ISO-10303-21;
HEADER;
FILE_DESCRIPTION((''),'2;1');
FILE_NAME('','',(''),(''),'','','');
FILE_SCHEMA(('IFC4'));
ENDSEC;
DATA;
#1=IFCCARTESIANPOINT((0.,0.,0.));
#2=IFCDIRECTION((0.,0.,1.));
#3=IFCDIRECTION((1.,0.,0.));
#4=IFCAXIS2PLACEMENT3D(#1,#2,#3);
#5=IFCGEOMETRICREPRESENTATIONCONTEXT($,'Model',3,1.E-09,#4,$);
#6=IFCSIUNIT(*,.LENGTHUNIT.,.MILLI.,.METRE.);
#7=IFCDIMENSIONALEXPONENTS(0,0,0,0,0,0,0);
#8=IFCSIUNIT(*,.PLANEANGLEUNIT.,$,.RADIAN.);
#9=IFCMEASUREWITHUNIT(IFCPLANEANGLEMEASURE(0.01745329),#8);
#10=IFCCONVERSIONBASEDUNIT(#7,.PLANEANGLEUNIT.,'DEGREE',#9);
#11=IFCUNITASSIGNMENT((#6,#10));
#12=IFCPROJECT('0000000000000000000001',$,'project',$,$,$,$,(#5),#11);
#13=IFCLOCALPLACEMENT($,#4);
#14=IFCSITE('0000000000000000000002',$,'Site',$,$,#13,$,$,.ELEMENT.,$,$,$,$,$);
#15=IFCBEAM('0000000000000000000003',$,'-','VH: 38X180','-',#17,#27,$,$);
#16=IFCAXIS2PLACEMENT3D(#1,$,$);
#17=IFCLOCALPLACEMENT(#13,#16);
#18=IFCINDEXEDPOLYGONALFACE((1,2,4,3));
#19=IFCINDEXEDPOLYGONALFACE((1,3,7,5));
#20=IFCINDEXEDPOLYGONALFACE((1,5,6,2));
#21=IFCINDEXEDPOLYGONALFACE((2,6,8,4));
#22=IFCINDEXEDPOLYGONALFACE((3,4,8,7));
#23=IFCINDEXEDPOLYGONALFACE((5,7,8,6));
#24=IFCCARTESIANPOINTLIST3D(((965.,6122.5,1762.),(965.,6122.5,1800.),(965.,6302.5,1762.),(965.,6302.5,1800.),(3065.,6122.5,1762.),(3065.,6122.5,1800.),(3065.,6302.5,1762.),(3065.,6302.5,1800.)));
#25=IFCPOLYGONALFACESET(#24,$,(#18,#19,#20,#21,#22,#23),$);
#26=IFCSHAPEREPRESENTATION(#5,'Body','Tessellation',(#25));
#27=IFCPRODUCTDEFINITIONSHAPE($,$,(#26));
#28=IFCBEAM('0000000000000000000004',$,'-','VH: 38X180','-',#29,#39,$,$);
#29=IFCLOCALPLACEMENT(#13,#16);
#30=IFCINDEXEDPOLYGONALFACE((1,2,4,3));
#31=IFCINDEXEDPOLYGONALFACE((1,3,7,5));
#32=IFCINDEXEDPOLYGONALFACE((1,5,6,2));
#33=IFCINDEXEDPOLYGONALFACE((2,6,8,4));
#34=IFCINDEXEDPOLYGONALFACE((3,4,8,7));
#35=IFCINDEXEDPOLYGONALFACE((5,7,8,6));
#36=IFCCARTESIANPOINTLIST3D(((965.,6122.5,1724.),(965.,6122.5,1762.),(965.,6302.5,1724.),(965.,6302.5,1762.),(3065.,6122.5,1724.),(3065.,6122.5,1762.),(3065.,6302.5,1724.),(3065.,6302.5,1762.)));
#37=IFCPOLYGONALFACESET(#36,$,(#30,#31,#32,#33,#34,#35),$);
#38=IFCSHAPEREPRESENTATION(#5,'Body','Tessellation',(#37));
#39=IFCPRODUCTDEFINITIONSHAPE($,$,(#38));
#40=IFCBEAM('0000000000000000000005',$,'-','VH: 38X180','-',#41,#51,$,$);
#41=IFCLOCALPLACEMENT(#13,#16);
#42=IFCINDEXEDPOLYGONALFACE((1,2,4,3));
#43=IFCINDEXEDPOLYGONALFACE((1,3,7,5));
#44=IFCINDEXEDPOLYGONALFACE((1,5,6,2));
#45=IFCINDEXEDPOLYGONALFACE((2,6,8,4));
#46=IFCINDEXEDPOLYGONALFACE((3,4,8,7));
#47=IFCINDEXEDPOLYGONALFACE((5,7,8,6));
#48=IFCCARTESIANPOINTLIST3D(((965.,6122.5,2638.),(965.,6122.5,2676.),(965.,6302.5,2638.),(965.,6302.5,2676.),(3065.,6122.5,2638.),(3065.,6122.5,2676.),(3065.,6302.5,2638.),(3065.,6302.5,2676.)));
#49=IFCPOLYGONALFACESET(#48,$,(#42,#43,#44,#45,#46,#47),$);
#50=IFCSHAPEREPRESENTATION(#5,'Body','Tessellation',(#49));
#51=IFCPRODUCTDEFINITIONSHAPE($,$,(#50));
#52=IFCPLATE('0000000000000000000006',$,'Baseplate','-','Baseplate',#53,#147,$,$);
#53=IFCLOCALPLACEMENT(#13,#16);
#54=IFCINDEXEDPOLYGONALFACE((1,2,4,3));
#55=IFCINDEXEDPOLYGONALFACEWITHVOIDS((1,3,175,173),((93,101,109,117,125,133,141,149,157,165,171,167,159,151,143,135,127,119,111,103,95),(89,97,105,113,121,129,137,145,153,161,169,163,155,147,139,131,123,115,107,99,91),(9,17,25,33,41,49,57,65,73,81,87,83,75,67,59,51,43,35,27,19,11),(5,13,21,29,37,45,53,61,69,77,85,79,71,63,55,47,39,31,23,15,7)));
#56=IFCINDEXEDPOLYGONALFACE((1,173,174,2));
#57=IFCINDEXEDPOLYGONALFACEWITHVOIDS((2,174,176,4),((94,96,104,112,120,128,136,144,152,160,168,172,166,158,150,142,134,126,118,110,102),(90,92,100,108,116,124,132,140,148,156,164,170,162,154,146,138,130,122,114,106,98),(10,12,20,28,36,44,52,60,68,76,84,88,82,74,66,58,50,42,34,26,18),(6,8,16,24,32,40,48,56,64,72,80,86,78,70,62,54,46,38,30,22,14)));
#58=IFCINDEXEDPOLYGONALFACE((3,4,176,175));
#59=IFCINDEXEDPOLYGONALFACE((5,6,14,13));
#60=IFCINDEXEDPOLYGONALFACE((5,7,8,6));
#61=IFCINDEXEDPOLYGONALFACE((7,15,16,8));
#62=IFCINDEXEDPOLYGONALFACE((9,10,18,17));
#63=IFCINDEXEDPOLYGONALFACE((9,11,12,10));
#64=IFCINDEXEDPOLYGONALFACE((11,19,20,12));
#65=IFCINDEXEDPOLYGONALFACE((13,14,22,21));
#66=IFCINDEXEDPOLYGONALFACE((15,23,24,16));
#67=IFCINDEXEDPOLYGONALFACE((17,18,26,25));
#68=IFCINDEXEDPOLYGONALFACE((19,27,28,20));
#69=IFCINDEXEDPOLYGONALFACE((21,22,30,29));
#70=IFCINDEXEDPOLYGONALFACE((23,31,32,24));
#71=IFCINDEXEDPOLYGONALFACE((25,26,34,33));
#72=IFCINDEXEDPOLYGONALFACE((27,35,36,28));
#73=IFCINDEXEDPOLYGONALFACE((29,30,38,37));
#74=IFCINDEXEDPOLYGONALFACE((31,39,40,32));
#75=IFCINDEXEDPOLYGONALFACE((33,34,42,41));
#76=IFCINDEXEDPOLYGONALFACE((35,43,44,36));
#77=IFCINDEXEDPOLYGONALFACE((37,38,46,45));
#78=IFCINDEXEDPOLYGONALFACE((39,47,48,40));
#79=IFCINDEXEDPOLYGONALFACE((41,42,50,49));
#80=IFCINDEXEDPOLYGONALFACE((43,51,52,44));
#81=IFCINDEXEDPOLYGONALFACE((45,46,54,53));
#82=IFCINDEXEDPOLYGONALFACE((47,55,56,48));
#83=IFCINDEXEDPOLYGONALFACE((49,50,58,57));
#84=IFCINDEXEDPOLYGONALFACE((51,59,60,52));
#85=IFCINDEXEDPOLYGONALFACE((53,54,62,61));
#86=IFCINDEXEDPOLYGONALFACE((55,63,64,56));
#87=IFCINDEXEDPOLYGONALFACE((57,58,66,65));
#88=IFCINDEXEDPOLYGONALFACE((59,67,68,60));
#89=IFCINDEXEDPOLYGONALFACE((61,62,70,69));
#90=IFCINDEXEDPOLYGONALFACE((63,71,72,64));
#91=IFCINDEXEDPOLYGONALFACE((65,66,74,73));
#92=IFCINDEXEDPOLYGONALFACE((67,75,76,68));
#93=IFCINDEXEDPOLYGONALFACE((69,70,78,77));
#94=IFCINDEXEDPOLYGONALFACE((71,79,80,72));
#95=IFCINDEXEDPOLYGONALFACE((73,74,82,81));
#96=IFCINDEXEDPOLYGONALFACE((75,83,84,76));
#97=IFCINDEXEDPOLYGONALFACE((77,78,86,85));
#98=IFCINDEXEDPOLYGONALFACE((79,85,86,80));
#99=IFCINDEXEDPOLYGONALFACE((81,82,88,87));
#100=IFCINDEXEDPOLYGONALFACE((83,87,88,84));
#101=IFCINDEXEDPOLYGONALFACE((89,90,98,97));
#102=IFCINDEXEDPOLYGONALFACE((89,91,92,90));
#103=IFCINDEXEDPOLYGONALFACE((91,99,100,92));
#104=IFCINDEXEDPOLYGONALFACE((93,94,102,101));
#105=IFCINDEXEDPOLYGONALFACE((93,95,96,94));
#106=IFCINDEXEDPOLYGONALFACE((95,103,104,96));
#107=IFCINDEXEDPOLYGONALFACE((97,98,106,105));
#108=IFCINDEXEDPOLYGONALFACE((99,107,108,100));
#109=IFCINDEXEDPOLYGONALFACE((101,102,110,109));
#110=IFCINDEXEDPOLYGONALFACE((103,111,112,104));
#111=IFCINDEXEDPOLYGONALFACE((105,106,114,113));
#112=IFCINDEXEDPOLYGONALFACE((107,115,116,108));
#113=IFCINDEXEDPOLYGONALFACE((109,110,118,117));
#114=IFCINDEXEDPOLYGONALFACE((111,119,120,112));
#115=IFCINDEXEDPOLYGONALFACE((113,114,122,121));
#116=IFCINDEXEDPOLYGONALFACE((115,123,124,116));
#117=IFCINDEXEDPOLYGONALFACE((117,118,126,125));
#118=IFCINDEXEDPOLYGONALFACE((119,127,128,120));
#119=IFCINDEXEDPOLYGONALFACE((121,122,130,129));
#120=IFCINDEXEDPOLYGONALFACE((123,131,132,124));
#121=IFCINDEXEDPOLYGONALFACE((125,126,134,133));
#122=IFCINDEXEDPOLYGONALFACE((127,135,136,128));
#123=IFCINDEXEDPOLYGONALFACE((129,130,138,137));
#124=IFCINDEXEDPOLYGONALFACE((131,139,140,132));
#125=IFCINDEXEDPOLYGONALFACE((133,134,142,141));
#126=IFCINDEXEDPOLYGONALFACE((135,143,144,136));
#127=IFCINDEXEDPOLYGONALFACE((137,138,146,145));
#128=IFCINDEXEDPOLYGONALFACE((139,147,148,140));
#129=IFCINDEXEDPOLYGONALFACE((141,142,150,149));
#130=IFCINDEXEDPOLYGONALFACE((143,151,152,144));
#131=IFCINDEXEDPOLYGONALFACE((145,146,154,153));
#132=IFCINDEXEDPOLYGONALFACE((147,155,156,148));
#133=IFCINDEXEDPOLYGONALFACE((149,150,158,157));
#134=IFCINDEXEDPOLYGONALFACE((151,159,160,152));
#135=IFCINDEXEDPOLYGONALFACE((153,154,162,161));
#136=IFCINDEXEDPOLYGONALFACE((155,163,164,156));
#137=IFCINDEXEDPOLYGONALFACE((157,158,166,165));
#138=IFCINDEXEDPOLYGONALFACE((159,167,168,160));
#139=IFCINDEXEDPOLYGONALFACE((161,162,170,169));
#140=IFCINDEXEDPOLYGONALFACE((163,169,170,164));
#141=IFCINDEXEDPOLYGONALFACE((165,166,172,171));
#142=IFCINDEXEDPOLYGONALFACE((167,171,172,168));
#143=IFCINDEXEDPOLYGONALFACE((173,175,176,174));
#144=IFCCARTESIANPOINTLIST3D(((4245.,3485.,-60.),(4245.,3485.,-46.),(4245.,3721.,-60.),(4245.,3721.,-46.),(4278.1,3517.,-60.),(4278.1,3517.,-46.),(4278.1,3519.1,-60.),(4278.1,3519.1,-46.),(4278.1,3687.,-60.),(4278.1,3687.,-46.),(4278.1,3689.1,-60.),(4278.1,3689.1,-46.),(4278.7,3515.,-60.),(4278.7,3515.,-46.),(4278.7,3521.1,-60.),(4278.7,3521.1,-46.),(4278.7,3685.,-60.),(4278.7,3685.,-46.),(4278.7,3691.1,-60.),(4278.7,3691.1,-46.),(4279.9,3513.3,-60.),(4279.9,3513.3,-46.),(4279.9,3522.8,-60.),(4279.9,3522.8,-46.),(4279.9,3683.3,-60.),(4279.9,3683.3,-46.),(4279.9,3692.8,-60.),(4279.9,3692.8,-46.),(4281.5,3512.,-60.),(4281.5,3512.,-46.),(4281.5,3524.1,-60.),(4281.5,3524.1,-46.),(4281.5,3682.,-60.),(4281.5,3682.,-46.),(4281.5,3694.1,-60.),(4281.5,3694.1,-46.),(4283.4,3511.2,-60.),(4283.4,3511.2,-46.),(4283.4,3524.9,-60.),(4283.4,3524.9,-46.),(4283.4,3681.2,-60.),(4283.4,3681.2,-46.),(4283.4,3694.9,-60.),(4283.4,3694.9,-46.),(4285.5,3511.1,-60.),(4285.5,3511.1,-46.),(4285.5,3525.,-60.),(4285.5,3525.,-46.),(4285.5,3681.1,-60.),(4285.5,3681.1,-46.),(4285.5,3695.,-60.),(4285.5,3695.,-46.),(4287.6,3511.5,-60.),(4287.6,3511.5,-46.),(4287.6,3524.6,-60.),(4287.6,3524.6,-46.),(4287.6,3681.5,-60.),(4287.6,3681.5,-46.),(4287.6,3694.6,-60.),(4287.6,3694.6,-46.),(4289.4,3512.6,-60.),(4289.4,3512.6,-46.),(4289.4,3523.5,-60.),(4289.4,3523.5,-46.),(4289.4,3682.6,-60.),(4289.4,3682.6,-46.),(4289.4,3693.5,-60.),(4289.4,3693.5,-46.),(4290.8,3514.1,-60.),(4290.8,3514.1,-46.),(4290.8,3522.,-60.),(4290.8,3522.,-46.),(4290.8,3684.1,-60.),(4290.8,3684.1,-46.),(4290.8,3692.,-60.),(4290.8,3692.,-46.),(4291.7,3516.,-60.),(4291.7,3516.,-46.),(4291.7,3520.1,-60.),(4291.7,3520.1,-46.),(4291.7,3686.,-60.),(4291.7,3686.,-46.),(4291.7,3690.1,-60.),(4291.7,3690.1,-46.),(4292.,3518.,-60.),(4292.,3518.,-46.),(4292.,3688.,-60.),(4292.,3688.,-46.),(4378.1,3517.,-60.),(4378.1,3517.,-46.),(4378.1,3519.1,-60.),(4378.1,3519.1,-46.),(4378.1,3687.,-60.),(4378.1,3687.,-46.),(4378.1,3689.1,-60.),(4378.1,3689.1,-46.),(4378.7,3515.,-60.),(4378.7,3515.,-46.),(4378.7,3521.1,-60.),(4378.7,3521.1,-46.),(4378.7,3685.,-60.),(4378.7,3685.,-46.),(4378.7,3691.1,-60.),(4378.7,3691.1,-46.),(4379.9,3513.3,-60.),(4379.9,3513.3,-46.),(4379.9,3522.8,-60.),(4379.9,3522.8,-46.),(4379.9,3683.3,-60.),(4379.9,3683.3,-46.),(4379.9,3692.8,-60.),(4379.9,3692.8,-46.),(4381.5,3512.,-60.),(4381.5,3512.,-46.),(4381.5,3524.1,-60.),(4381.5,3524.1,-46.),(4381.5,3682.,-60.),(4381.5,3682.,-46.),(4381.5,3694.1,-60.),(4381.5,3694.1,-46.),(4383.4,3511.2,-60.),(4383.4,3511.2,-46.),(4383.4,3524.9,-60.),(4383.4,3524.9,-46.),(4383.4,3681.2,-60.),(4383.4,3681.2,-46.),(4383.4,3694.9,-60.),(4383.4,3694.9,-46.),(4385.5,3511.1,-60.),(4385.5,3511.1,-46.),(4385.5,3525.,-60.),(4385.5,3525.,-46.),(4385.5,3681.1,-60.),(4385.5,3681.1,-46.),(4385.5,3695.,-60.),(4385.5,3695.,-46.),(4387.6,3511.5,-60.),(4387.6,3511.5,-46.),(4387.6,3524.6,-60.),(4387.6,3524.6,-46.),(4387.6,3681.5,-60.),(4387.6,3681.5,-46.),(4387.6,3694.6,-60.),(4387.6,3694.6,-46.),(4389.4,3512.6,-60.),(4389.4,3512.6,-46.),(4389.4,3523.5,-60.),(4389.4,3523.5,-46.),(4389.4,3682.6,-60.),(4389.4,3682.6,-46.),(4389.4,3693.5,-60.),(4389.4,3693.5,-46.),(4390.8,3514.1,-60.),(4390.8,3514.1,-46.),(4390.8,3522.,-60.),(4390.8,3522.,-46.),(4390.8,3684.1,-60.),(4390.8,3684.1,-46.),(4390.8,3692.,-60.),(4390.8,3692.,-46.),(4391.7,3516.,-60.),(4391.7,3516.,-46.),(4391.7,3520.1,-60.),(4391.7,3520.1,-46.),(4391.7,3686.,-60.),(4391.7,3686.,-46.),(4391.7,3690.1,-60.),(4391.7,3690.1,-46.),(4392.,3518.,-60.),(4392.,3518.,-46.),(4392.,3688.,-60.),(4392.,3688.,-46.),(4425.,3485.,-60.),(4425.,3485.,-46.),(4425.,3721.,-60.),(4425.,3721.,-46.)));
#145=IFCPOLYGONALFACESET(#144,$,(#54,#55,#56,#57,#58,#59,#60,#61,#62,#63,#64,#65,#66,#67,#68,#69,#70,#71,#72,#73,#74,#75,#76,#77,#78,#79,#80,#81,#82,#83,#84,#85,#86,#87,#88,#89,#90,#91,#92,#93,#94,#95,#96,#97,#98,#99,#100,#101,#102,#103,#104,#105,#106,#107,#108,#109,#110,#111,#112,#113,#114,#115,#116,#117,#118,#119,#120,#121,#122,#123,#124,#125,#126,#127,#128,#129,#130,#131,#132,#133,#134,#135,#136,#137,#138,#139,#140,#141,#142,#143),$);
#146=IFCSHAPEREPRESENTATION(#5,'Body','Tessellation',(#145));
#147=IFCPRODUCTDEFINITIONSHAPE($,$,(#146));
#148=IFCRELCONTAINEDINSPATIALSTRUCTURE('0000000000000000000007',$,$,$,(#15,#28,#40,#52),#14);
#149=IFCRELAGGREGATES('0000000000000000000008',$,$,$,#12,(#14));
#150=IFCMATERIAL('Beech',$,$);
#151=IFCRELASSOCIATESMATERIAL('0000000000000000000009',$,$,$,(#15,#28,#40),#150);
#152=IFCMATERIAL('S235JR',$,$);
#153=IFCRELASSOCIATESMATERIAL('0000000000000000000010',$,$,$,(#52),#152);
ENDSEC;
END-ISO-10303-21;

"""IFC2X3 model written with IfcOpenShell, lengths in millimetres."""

from ifc_helpers import new_model, entity, si_unit, converted_unit, frame, frame_2d, origin, origin_with_axes, origin_2d, place, context, project, spatial, polyline, rectangle, circle, outline, extrude, material, element, save


model = new_model("IFC2X3")

# Units and contexts
model_context = context("Model", 3, precision=1e-09, world=origin_with_axes())
ifc_project = project(units=[si_unit("LENGTHUNIT", "METRE", prefix="MILLI"), converted_unit("PLANEANGLEUNIT", "DEGREE", entity("IfcPlaneAngleMeasure", 0.01745329), si_unit("PLANEANGLEUNIT", "RADIAN"), dimensions=[0, 0, 0, 0, 0, 0, 0])], contexts=[model_context])

# Site
site_placement = place(None, origin_with_axes())
site = spatial("IfcSite", under=ifc_project, at=site_placement, Name="Site", CompositionType="ELEMENT")

# Shared definitions
ifc_material_1 = material(Name="Beech")

# Beams
beam_1_placement = place(None, frame((3065.0, 6212.5, 1781.0), z_axis=(1.0, 0.0, 0.0), x_axis=(0.0, 0.0, -1.0)))
element("IfcBeam", 1, at=beam_1_placement, inside=site, material=ifc_material_1, Name="-", Description="VH: 38X180", ObjectType="-", context=model_context, shape_type="SweptSolid", body=[
    extrude(rectangle(XDim=38.0, YDim=180.0, at=origin_2d()), origin(), (0.0, 0.0, -1.0), 2100.0),
])
beam_2_placement = place(None, frame((3065.0, 6212.5, 1743.0), z_axis=(1.0, 0.0, 0.0), x_axis=(0.0, 0.0, -1.0)))
element("IfcBeam", 2, at=beam_2_placement, inside=site, material=ifc_material_1, Name="-", Description="VH: 38X180", ObjectType="-", context=model_context, shape_type="SweptSolid", body=[
    extrude(rectangle(XDim=38.0, YDim=180.0, at=origin_2d()), origin(), (0.0, 0.0, -1.0), 2100.0),
])
beam_3_placement = place(None, frame((3065.0, 6212.5, 2657.0), z_axis=(1.0, 0.0, 0.0), x_axis=(0.0, 0.0, -1.0)))
element("IfcBeam", 3, at=beam_3_placement, inside=site, material=ifc_material_1, Name="-", Description="VH: 38X180", ObjectType="-", context=model_context, shape_type="SweptSolid", body=[
    extrude(rectangle(XDim=38.0, YDim=180.0, at=origin_2d()), origin(), (0.0, 0.0, -1.0), 2100.0),
])

# Plate, openings
ifc_material_2 = material(Name="S235JR")
plate_placement = place(None, frame((4245.0, 3721.0, -46.0), z_axis=(0.0, 0.0, -1.0), x_axis=(1.0, 0.0, 0.0)))
plate = element("IfcPlate", 4, at=plate_placement, inside=site, material=ifc_material_2, Name="Baseplate", Description="-", ObjectType="Baseplate", context=model_context, shape_type="SweptSolid", body=[
    extrude(outline(polyline([(0.0, 0.0), (180.0, 0.0), (180.0, 236.0), (0.0, 236.0), (0.0, 0.0)])), origin_with_axes(), (0.0, 0.0, 1.0), 14.0),
])
opening_1_placement = place(plate_placement, frame((90.0, 118.0, 14.5), z_axis=(0.0, 0.0, -1.0), x_axis=(1.0, 0.0, 0.0)))
element("IfcOpeningElement", 5, at=opening_1_placement, cuts=plate, ObjectType="Opening", context=model_context, shape_type="SweptSolid", body=[
    extrude(circle(Radius=7.0, at=frame_2d((50.0, 85.0), x_axis=(1.0, 0.0))), origin(), (0.0, 0.0, 1.0), 15.0),
])
opening_2_placement = place(plate_placement, frame((90.0, 118.0, 14.5), z_axis=(0.0, 0.0, -1.0), x_axis=(1.0, 0.0, 0.0)))
element("IfcOpeningElement", 6, at=opening_2_placement, cuts=plate, ObjectType="Opening", context=model_context, shape_type="SweptSolid", body=[
    extrude(circle(Radius=7.0, at=frame_2d((-50.0, 85.0), x_axis=(1.0, 0.0))), origin(), (0.0, 0.0, 1.0), 15.0),
])
opening_3_placement = place(plate_placement, frame((90.0, 118.0, 14.5), z_axis=(0.0, 0.0, -1.0), x_axis=(1.0, 0.0, 0.0)))
element("IfcOpeningElement", 7, at=opening_3_placement, cuts=plate, ObjectType="Opening", context=model_context, shape_type="SweptSolid", body=[
    extrude(circle(Radius=7.0, at=frame_2d((50.0, -85.0), x_axis=(1.0, 0.0))), origin(), (0.0, 0.0, 1.0), 15.0),
])
opening_4_placement = place(plate_placement, frame((90.0, 118.0, 14.5), z_axis=(0.0, 0.0, -1.0), x_axis=(1.0, 0.0, 0.0)))
element("IfcOpeningElement", 8, at=opening_4_placement, cuts=plate, ObjectType="Opening", context=model_context, shape_type="SweptSolid", body=[
    extrude(circle(Radius=7.0, at=frame_2d((-50.0, -85.0), x_axis=(1.0, 0.0))), origin(), (0.0, 0.0, 1.0), 15.0),
])

save(model, "model.ifc")
